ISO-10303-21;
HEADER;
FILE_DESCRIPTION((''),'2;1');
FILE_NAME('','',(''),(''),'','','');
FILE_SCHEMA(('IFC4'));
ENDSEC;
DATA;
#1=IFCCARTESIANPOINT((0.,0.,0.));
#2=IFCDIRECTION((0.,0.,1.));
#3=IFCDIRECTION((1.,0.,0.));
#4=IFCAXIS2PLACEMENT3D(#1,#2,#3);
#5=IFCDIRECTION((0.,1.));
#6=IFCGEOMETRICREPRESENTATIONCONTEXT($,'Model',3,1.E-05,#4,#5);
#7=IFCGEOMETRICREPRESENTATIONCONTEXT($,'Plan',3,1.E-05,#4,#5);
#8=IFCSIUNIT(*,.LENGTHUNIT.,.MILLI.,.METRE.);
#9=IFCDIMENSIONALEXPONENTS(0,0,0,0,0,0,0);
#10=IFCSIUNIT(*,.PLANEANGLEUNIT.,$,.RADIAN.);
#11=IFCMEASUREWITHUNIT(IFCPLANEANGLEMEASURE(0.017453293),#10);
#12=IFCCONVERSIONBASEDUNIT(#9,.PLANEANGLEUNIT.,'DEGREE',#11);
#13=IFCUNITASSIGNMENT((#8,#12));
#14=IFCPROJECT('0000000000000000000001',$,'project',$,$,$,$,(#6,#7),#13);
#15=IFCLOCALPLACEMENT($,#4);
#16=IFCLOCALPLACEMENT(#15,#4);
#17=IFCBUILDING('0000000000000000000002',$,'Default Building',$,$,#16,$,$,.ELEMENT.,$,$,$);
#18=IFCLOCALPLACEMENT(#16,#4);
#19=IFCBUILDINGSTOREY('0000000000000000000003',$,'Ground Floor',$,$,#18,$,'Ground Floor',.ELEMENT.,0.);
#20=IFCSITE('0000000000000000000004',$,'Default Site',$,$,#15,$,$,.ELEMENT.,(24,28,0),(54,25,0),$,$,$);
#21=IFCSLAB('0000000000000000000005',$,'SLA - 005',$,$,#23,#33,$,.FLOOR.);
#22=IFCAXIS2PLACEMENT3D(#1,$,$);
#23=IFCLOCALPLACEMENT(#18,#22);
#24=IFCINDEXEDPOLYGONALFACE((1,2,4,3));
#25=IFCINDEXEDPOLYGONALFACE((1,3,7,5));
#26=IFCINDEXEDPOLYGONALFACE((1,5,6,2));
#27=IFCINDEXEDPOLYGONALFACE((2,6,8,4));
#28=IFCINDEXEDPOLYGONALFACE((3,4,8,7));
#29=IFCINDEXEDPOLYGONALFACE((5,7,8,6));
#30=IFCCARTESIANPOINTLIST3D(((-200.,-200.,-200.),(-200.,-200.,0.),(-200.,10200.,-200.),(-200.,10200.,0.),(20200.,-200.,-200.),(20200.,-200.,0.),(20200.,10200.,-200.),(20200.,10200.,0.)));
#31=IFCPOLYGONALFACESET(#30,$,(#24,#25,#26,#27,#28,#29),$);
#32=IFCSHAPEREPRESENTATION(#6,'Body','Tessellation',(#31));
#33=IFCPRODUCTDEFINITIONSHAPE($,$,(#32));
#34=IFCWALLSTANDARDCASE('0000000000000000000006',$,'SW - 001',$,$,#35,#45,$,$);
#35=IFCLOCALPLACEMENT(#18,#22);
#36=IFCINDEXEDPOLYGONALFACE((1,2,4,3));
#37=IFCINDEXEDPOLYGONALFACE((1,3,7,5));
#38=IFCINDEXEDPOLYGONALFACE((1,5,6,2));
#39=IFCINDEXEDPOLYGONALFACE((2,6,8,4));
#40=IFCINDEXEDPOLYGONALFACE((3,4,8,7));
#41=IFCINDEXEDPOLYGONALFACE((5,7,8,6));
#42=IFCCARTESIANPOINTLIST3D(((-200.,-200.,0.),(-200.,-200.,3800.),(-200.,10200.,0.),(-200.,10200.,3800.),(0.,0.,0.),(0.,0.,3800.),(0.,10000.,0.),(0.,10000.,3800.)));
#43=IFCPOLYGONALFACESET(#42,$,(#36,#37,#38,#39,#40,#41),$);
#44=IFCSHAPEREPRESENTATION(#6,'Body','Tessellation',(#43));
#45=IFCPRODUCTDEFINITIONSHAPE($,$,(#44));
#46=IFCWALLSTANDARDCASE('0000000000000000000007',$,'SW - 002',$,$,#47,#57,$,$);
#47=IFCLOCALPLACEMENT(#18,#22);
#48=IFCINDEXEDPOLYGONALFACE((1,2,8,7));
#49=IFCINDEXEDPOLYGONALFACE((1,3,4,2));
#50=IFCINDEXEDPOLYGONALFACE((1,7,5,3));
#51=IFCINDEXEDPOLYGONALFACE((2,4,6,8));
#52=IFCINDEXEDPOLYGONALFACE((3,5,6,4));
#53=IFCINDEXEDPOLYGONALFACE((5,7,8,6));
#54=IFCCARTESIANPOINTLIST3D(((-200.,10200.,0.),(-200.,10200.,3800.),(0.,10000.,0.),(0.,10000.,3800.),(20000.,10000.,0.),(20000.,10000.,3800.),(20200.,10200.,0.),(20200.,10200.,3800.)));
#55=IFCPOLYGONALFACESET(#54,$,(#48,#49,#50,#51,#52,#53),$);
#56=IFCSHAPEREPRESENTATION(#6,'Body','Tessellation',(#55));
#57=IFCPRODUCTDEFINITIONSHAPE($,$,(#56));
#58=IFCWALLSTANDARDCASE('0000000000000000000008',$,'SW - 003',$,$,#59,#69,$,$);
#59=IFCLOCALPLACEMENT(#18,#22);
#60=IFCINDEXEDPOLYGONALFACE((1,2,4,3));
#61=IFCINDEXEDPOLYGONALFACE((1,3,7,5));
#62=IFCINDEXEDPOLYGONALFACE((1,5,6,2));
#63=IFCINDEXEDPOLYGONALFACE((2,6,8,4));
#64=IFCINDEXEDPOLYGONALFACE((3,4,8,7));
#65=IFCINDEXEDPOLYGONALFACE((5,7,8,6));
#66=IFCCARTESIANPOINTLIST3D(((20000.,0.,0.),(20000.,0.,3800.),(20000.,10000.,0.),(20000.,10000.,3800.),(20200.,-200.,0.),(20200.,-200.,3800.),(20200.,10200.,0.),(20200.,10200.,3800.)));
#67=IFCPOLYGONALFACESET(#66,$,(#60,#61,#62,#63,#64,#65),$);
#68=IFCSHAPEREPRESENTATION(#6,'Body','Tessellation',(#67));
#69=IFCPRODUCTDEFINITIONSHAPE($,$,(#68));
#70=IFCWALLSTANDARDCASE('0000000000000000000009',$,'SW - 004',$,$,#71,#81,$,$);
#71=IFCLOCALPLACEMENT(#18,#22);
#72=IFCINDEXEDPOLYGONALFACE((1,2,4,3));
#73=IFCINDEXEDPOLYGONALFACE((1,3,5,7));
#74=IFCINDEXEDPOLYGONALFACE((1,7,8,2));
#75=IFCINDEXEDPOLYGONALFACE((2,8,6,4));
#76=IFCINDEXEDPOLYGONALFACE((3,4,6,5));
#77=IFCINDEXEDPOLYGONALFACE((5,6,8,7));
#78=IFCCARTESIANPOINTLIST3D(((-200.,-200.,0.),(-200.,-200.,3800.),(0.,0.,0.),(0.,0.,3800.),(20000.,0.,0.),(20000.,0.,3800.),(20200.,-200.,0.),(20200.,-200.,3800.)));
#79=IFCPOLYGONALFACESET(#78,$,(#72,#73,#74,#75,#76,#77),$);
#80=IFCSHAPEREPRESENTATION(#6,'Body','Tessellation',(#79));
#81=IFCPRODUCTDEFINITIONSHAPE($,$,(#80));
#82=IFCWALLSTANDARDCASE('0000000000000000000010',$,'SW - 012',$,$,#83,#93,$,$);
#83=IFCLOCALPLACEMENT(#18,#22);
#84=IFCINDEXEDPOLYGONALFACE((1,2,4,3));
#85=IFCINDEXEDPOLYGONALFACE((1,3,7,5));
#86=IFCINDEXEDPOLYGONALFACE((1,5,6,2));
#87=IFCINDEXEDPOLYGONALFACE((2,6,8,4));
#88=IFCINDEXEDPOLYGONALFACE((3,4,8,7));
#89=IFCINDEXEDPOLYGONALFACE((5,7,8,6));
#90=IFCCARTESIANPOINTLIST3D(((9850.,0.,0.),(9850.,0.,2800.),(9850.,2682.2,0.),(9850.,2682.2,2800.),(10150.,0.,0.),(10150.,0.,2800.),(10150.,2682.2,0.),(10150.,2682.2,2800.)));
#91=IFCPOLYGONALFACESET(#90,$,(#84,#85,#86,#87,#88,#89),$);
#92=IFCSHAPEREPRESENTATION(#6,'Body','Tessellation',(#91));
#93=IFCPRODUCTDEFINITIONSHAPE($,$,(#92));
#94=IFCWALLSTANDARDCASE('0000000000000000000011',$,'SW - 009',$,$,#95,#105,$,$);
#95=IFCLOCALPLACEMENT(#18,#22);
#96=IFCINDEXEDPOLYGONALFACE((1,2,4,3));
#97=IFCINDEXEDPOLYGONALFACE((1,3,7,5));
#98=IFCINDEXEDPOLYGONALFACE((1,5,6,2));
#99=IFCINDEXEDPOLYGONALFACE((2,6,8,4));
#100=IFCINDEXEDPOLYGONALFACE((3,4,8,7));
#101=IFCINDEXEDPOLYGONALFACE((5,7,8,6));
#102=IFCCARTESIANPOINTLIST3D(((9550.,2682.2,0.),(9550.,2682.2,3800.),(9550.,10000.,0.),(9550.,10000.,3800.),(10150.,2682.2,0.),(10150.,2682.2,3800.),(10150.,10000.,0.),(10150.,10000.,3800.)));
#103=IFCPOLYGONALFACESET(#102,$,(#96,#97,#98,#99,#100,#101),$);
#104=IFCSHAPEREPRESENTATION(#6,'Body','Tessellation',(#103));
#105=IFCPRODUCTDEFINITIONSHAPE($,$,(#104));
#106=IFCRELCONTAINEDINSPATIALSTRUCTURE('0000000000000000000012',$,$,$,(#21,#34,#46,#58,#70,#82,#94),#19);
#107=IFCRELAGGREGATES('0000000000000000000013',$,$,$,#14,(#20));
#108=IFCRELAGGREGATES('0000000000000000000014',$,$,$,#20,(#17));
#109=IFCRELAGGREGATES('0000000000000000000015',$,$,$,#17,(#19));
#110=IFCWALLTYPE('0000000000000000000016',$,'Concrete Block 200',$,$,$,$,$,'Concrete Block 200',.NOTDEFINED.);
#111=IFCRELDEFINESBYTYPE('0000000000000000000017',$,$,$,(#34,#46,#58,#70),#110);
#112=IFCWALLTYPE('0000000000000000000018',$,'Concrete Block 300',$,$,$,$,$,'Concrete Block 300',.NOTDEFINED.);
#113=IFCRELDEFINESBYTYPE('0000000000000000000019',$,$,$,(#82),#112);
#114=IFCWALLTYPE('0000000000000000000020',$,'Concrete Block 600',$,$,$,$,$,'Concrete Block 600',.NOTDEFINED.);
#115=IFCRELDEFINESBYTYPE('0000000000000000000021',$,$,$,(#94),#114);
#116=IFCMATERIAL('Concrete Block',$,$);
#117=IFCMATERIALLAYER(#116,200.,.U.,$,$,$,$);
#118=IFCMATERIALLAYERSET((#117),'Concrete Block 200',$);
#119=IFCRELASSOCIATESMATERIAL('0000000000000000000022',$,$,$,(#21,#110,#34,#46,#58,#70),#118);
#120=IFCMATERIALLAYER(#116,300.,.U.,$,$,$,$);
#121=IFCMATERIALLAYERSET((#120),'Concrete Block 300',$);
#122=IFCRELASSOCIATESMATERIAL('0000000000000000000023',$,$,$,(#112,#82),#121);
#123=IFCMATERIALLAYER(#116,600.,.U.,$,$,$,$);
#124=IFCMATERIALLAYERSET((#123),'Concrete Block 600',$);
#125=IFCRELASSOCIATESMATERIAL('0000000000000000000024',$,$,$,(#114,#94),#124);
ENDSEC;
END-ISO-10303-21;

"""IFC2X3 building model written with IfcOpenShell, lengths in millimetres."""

from ifc_helpers import new_model, entity, si_unit, converted_unit, direction, frame, origin_with_axes, place, context, project, spatial, polyline, outline, extrude, material, layer, layer_set, layer_usage, type_object, element, save


model = new_model("IFC2X3")

# Units and contexts
model_context = context("Model", 3, precision=1e-05, world=origin_with_axes(), true_north=direction((0.0, 1.0)))
plan_context = context("Plan", 3, precision=1e-05, world=origin_with_axes(), true_north=direction((0.0, 1.0)))
ifc_project = project(units=[si_unit("LENGTHUNIT", "METRE", prefix="MILLI"), converted_unit("PLANEANGLEUNIT", "DEGREE", entity("IfcPlaneAngleMeasure", 0.017453293), si_unit("PLANEANGLEUNIT", "RADIAN"), dimensions=[0, 0, 0, 0, 0, 0, 0])], contexts=[model_context, plan_context])

# Site, building, storey
site_placement = place(None, origin_with_axes())
site = spatial("IfcSite", under=ifc_project, at=site_placement, Name="Default Site", CompositionType="ELEMENT", RefLatitude=(24, 28, 0), RefLongitude=(54, 25, 0))
building_placement = place(site_placement, origin_with_axes())
building = spatial("IfcBuilding", under=site, at=building_placement, Name="Default Building", CompositionType="ELEMENT")
storey_placement = place(building_placement, origin_with_axes())
storey = spatial("IfcBuildingStorey", under=building, at=storey_placement, Name="Ground Floor", LongName="Ground Floor", CompositionType="ELEMENT", Elevation=0.0)

# Slab
ifc_material = material(Name="Concrete Block")
ifc_layer_1 = layer(ifc_material, 200.0, ventilated="UNKNOWN")
ifc_layer_set_1 = layer_set([ifc_layer_1], Name="Concrete Block 200")
ifc_layer_usage_1 = layer_usage(ifc_layer_set_1, "AXIS3", "NEGATIVE", 200.0)
slab_placement = place(storey_placement, frame((-200.0, 10200.0, -200.0), z_axis=(0.0, 0.0, 1.0), x_axis=(1.0, 0.0, 0.0)))
element("IfcSlab", 1, at=slab_placement, inside=storey, material=ifc_layer_usage_1, Name="SLA - 005", PredefinedType="FLOOR", context=model_context, shape_type="SweptSolid", body=[
    extrude(outline(polyline([(0.0, 0.0), (20400.0, 0.0), (20400.0, -10400.0), (0.0, -10400.0), (0.0, 0.0)])), origin_with_axes(), (0.0, 0.0, 1.0), 200.0),
])

# Walls
ifc_layer_usage_2 = layer_usage(ifc_layer_set_1, "AXIS2", "POSITIVE", 0.0)
wall_type_1 = type_object("IfcWallType", Name="Concrete Block 200", ElementType="Concrete Block 200", PredefinedType="NOTDEFINED", material=ifc_layer_set_1)
wall_1_placement = place(storey_placement, frame((0.0, 0.0, 0.0), z_axis=(0.0, 0.0, 1.0), x_axis=(0.0, 1.0, 0.0)))
element("IfcWallStandardCase", 2, at=wall_1_placement, inside=storey, type_object=wall_type_1, material=ifc_layer_usage_2, Name="SW - 001", context=model_context, shape_type="SweptSolid", body=[
    extrude(outline(polyline([(0.0, 0.0), (10000.0, 0.0), (10200.0, 200.0), (-200.0, 200.0), (0.0, 0.0)])), origin_with_axes(), (0.0, 0.0, 1.0), 3800.0),
])
ifc_layer_usage_3 = layer_usage(ifc_layer_set_1, "AXIS2", "POSITIVE", 0.0)
wall_2_placement = place(storey_placement, frame((0.0, 10000.0, 0.0), z_axis=(0.0, 0.0, 1.0), x_axis=(1.0, 0.0, 0.0)))
element("IfcWallStandardCase", 3, at=wall_2_placement, inside=storey, type_object=wall_type_1, material=ifc_layer_usage_3, Name="SW - 002", context=model_context, shape_type="SweptSolid", body=[
    extrude(outline(polyline([(0.0, 0.0), (20000.0, 0.0), (20200.0, 200.0), (-200.0, 200.0), (0.0, 0.0)])), origin_with_axes(), (0.0, 0.0, 1.0), 3800.0),
])
ifc_layer_usage_4 = layer_usage(ifc_layer_set_1, "AXIS2", "POSITIVE", 0.0)
wall_3_placement = place(storey_placement, frame((20000.0, 10000.0, 0.0), z_axis=(0.0, 0.0, 1.0), x_axis=(0.0, -1.0, 0.0)))
element("IfcWallStandardCase", 4, at=wall_3_placement, inside=storey, type_object=wall_type_1, material=ifc_layer_usage_4, Name="SW - 003", context=model_context, shape_type="SweptSolid", body=[
    extrude(outline(polyline([(0.0, 0.0), (10000.0, 0.0), (10200.0, 200.0), (-200.0, 200.0), (0.0, 0.0)])), origin_with_axes(), (0.0, 0.0, 1.0), 3800.0),
])
ifc_layer_usage_5 = layer_usage(ifc_layer_set_1, "AXIS2", "POSITIVE", 0.0)
wall_4_placement = place(storey_placement, frame((20000.0, 0.0, 0.0), z_axis=(0.0, 0.0, 1.0), x_axis=(-1.0, 0.0, 0.0)))
element("IfcWallStandardCase", 5, at=wall_4_placement, inside=storey, type_object=wall_type_1, material=ifc_layer_usage_5, Name="SW - 004", context=model_context, shape_type="SweptSolid", body=[
    extrude(outline(polyline([(0.0, 0.0), (20000.0, 0.0), (20200.0, 200.0), (-200.0, 200.0), (0.0, 0.0)])), origin_with_axes(), (0.0, 0.0, 1.0), 3800.0),
])
ifc_layer_2 = layer(ifc_material, 300.0, ventilated="UNKNOWN")
ifc_layer_set_2 = layer_set([ifc_layer_2], Name="Concrete Block 300")
wall_type_2 = type_object("IfcWallType", Name="Concrete Block 300", ElementType="Concrete Block 300", PredefinedType="NOTDEFINED", material=ifc_layer_set_2)
ifc_layer_usage_6 = layer_usage(ifc_layer_set_2, "AXIS2", "POSITIVE", 0.0)
wall_5_placement = place(storey_placement, frame((10150.0, 0.0, 0.0), z_axis=(0.0, 0.0, 1.0), x_axis=(0.0, 1.0, 0.0)))
element("IfcWallStandardCase", 6, at=wall_5_placement, inside=storey, type_object=wall_type_2, material=ifc_layer_usage_6, Name="SW - 012", context=model_context, shape_type="SweptSolid", body=[
    extrude(outline(polyline([(0.0, 0.0), (2682.2, 0.0), (2682.2, 300.0), (0.0, 300.0), (0.0, 0.0)])), origin_with_axes(), (0.0, 0.0, 1.0), 2800.0),
])
ifc_layer_3 = layer(ifc_material, 600.0, ventilated="UNKNOWN")
ifc_layer_set_3 = layer_set([ifc_layer_3], Name="Concrete Block 600")
ifc_layer_usage_7 = layer_usage(ifc_layer_set_3, "AXIS2", "POSITIVE", 0.0)
wall_type_3 = type_object("IfcWallType", Name="Concrete Block 600", ElementType="Concrete Block 600", PredefinedType="NOTDEFINED", material=ifc_layer_set_3)
wall_6_placement = place(storey_placement, frame((10150.0, 2682.2, 0.0), z_axis=(0.0, 0.0, 1.0), x_axis=(0.0, 1.0, 0.0)))
element("IfcWallStandardCase", 7, at=wall_6_placement, inside=storey, type_object=wall_type_3, material=ifc_layer_usage_7, Name="SW - 009", context=model_context, shape_type="SweptSolid", body=[
    extrude(outline(polyline([(0.0, 0.0), (7317.8, 0.0), (7317.8, 600.0), (0.0, 600.0), (0.0, 0.0)])), origin_with_axes(), (0.0, 0.0, 1.0), 3800.0),
])

save(model, "model.ifc")
